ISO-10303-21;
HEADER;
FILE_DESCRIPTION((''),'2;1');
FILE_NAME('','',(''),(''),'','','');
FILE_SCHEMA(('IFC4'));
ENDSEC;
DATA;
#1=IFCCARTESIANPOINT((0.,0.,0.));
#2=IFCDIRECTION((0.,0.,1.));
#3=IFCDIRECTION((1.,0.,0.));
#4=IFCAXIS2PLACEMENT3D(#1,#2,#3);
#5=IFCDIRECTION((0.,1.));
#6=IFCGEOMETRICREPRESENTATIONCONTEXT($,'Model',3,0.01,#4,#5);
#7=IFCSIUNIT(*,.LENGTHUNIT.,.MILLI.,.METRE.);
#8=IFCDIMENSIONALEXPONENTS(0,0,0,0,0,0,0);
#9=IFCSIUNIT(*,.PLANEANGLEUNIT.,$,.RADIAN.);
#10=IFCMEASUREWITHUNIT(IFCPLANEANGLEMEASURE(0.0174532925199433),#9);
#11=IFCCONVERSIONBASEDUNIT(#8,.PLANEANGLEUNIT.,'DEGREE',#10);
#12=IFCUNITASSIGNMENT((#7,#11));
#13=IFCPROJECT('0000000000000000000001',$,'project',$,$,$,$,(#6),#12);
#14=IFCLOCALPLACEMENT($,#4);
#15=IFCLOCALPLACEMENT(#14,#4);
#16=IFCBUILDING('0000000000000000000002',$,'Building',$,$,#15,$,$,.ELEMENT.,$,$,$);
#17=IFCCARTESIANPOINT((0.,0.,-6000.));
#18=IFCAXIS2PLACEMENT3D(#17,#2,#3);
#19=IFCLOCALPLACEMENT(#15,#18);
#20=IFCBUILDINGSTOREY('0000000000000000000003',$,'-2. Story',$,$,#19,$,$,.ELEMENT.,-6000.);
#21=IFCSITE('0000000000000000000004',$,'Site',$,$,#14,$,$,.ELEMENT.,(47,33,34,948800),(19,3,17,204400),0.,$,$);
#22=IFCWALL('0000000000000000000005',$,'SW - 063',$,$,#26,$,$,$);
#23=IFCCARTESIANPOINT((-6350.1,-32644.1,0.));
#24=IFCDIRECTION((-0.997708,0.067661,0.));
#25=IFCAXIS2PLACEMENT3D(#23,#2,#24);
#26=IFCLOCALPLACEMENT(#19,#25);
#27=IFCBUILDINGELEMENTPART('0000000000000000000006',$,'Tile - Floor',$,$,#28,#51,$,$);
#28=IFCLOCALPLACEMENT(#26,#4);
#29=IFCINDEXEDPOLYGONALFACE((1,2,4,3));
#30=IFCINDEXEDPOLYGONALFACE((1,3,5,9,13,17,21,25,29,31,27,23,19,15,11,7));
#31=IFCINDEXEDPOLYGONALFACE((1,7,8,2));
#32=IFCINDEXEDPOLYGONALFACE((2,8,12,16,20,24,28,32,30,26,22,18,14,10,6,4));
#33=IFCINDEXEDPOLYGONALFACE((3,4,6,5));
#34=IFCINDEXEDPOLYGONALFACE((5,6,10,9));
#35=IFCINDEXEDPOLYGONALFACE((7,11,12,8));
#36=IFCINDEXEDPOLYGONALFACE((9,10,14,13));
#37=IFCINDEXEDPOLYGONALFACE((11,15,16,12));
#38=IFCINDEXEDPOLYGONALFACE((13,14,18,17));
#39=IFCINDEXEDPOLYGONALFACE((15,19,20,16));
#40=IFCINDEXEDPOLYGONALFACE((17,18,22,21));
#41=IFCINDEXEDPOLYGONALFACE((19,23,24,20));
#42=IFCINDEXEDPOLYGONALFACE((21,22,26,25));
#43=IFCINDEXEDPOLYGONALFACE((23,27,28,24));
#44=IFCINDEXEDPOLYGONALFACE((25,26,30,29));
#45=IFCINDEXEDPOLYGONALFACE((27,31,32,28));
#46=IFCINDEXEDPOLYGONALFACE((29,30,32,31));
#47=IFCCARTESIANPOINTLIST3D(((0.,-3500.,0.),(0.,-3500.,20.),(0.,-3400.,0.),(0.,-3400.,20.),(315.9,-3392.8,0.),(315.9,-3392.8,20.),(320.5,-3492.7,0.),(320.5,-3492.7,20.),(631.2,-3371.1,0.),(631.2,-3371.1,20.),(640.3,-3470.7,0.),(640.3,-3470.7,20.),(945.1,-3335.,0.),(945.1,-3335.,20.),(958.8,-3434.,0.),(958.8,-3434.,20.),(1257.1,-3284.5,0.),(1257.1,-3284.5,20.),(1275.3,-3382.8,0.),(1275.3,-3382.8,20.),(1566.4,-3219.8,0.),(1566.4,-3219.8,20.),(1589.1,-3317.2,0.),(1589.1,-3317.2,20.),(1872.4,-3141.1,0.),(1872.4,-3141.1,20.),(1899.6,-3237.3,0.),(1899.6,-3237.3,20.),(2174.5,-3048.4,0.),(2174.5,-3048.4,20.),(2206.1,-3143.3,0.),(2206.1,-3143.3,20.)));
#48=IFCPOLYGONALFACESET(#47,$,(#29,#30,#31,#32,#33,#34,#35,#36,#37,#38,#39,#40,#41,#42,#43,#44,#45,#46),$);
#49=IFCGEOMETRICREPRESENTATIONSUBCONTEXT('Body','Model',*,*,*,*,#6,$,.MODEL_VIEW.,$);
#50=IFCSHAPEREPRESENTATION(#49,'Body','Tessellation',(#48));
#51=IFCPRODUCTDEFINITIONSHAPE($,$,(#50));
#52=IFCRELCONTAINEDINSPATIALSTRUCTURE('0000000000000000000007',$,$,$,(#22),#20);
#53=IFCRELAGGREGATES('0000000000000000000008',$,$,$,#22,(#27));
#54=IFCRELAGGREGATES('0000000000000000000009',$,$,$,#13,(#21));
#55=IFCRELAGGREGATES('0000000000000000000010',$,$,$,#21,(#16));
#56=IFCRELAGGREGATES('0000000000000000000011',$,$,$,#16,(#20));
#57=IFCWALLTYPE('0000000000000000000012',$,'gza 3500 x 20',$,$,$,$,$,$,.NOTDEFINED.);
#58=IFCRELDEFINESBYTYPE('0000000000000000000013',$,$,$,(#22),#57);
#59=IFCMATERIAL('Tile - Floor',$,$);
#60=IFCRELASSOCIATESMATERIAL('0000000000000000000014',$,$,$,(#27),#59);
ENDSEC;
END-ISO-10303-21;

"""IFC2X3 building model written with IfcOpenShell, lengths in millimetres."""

from ifc_helpers import new_model, entity, si_unit, converted_unit, direction, frame, origin_with_axes, place, context, subcontext, project, spatial, material, type_object, element, aggregate, save


model = new_model("IFC2X3")

# Units and contexts
model_context = context("Model", 3, precision=0.01, world=origin_with_axes(), true_north=direction((0.0, 1.0)))
body_context = subcontext(model_context, "Body", "Model", "MODEL_VIEW")
ifc_project = project(units=[si_unit("LENGTHUNIT", "METRE", prefix="MILLI"), converted_unit("PLANEANGLEUNIT", "DEGREE", entity("IfcPlaneAngleMeasure", 0.0174532925199433), si_unit("PLANEANGLEUNIT", "RADIAN"), dimensions=[0, 0, 0, 0, 0, 0, 0])], contexts=[model_context])

# Site, building, storey
site_placement = place(None, origin_with_axes())
site = spatial("IfcSite", under=ifc_project, at=site_placement, Name="Site", CompositionType="ELEMENT", RefLatitude=(47, 33, 34, 948800), RefLongitude=(19, 3, 17, 204400), RefElevation=0.0)
building_placement = place(site_placement, origin_with_axes())
building = spatial("IfcBuilding", under=site, at=building_placement, Name="Building", CompositionType="ELEMENT")
storey_placement = place(building_placement, frame((0.0, 0.0, -6000.0), z_axis=(0.0, 0.0, 1.0), x_axis=(1.0, 0.0, 0.0)))
storey = spatial("IfcBuildingStorey", under=building, at=storey_placement, Name="-2. Story", CompositionType="ELEMENT", Elevation=-6000.0)

# Wall, building element part
wall_type_1 = type_object("IfcWallType", Name="gza 3500 x 20", PredefinedType="NOTDEFINED")
ifc_material_1 = material(Name="Tile - Floor")
wall_1_placement = place(storey_placement, frame((-6350.1, -32644.1, 0.0), z_axis=(0.0, 0.0, 1.0), x_axis=(-0.997708, 0.067661, 0.0)))
wall_1 = element("IfcWall", 1, at=wall_1_placement, inside=storey, type_object=wall_type_1, Name="SW - 063")
building_element_part_1_placement = place(wall_1_placement, origin_with_axes())
cartesian_point_1 = entity("IfcCartesianPoint", [3400.0, 20.0])
building_element_part_1 = element("IfcBuildingElementPart", 2, at=building_element_part_1_placement, material=ifc_material_1, Name="Tile - Floor", context=body_context, shape_type="SweptSolid", body=[
    entity("IfcRevolvedAreaSolid", entity("IfcArbitraryClosedProfileDef", "AREA", None, entity("IfcPolyline", [cartesian_point_1, entity("IfcCartesianPoint", [3400.0, 0.0]), entity("IfcCartesianPoint", [3500.0, 0.0]), entity("IfcCartesianPoint", [3500.0, 20.0]), cartesian_point_1])), entity("IfcAxis2Placement3D", entity("IfcCartesianPoint", [0.0, 0.0, 0.0]), entity("IfcDirection", [-1.0, 0.0, 0.0]), entity("IfcDirection", [0.0, -1.0, 0.0])), entity("IfcAxis1Placement", entity("IfcCartesianPoint", [-3500.0, 0.0, 0.0]), entity("IfcDirection", [0.0, 1.0, 0.0])), 18.369959),
])
aggregate(wall_1, [building_element_part_1])

save(model, "model.ifc")
